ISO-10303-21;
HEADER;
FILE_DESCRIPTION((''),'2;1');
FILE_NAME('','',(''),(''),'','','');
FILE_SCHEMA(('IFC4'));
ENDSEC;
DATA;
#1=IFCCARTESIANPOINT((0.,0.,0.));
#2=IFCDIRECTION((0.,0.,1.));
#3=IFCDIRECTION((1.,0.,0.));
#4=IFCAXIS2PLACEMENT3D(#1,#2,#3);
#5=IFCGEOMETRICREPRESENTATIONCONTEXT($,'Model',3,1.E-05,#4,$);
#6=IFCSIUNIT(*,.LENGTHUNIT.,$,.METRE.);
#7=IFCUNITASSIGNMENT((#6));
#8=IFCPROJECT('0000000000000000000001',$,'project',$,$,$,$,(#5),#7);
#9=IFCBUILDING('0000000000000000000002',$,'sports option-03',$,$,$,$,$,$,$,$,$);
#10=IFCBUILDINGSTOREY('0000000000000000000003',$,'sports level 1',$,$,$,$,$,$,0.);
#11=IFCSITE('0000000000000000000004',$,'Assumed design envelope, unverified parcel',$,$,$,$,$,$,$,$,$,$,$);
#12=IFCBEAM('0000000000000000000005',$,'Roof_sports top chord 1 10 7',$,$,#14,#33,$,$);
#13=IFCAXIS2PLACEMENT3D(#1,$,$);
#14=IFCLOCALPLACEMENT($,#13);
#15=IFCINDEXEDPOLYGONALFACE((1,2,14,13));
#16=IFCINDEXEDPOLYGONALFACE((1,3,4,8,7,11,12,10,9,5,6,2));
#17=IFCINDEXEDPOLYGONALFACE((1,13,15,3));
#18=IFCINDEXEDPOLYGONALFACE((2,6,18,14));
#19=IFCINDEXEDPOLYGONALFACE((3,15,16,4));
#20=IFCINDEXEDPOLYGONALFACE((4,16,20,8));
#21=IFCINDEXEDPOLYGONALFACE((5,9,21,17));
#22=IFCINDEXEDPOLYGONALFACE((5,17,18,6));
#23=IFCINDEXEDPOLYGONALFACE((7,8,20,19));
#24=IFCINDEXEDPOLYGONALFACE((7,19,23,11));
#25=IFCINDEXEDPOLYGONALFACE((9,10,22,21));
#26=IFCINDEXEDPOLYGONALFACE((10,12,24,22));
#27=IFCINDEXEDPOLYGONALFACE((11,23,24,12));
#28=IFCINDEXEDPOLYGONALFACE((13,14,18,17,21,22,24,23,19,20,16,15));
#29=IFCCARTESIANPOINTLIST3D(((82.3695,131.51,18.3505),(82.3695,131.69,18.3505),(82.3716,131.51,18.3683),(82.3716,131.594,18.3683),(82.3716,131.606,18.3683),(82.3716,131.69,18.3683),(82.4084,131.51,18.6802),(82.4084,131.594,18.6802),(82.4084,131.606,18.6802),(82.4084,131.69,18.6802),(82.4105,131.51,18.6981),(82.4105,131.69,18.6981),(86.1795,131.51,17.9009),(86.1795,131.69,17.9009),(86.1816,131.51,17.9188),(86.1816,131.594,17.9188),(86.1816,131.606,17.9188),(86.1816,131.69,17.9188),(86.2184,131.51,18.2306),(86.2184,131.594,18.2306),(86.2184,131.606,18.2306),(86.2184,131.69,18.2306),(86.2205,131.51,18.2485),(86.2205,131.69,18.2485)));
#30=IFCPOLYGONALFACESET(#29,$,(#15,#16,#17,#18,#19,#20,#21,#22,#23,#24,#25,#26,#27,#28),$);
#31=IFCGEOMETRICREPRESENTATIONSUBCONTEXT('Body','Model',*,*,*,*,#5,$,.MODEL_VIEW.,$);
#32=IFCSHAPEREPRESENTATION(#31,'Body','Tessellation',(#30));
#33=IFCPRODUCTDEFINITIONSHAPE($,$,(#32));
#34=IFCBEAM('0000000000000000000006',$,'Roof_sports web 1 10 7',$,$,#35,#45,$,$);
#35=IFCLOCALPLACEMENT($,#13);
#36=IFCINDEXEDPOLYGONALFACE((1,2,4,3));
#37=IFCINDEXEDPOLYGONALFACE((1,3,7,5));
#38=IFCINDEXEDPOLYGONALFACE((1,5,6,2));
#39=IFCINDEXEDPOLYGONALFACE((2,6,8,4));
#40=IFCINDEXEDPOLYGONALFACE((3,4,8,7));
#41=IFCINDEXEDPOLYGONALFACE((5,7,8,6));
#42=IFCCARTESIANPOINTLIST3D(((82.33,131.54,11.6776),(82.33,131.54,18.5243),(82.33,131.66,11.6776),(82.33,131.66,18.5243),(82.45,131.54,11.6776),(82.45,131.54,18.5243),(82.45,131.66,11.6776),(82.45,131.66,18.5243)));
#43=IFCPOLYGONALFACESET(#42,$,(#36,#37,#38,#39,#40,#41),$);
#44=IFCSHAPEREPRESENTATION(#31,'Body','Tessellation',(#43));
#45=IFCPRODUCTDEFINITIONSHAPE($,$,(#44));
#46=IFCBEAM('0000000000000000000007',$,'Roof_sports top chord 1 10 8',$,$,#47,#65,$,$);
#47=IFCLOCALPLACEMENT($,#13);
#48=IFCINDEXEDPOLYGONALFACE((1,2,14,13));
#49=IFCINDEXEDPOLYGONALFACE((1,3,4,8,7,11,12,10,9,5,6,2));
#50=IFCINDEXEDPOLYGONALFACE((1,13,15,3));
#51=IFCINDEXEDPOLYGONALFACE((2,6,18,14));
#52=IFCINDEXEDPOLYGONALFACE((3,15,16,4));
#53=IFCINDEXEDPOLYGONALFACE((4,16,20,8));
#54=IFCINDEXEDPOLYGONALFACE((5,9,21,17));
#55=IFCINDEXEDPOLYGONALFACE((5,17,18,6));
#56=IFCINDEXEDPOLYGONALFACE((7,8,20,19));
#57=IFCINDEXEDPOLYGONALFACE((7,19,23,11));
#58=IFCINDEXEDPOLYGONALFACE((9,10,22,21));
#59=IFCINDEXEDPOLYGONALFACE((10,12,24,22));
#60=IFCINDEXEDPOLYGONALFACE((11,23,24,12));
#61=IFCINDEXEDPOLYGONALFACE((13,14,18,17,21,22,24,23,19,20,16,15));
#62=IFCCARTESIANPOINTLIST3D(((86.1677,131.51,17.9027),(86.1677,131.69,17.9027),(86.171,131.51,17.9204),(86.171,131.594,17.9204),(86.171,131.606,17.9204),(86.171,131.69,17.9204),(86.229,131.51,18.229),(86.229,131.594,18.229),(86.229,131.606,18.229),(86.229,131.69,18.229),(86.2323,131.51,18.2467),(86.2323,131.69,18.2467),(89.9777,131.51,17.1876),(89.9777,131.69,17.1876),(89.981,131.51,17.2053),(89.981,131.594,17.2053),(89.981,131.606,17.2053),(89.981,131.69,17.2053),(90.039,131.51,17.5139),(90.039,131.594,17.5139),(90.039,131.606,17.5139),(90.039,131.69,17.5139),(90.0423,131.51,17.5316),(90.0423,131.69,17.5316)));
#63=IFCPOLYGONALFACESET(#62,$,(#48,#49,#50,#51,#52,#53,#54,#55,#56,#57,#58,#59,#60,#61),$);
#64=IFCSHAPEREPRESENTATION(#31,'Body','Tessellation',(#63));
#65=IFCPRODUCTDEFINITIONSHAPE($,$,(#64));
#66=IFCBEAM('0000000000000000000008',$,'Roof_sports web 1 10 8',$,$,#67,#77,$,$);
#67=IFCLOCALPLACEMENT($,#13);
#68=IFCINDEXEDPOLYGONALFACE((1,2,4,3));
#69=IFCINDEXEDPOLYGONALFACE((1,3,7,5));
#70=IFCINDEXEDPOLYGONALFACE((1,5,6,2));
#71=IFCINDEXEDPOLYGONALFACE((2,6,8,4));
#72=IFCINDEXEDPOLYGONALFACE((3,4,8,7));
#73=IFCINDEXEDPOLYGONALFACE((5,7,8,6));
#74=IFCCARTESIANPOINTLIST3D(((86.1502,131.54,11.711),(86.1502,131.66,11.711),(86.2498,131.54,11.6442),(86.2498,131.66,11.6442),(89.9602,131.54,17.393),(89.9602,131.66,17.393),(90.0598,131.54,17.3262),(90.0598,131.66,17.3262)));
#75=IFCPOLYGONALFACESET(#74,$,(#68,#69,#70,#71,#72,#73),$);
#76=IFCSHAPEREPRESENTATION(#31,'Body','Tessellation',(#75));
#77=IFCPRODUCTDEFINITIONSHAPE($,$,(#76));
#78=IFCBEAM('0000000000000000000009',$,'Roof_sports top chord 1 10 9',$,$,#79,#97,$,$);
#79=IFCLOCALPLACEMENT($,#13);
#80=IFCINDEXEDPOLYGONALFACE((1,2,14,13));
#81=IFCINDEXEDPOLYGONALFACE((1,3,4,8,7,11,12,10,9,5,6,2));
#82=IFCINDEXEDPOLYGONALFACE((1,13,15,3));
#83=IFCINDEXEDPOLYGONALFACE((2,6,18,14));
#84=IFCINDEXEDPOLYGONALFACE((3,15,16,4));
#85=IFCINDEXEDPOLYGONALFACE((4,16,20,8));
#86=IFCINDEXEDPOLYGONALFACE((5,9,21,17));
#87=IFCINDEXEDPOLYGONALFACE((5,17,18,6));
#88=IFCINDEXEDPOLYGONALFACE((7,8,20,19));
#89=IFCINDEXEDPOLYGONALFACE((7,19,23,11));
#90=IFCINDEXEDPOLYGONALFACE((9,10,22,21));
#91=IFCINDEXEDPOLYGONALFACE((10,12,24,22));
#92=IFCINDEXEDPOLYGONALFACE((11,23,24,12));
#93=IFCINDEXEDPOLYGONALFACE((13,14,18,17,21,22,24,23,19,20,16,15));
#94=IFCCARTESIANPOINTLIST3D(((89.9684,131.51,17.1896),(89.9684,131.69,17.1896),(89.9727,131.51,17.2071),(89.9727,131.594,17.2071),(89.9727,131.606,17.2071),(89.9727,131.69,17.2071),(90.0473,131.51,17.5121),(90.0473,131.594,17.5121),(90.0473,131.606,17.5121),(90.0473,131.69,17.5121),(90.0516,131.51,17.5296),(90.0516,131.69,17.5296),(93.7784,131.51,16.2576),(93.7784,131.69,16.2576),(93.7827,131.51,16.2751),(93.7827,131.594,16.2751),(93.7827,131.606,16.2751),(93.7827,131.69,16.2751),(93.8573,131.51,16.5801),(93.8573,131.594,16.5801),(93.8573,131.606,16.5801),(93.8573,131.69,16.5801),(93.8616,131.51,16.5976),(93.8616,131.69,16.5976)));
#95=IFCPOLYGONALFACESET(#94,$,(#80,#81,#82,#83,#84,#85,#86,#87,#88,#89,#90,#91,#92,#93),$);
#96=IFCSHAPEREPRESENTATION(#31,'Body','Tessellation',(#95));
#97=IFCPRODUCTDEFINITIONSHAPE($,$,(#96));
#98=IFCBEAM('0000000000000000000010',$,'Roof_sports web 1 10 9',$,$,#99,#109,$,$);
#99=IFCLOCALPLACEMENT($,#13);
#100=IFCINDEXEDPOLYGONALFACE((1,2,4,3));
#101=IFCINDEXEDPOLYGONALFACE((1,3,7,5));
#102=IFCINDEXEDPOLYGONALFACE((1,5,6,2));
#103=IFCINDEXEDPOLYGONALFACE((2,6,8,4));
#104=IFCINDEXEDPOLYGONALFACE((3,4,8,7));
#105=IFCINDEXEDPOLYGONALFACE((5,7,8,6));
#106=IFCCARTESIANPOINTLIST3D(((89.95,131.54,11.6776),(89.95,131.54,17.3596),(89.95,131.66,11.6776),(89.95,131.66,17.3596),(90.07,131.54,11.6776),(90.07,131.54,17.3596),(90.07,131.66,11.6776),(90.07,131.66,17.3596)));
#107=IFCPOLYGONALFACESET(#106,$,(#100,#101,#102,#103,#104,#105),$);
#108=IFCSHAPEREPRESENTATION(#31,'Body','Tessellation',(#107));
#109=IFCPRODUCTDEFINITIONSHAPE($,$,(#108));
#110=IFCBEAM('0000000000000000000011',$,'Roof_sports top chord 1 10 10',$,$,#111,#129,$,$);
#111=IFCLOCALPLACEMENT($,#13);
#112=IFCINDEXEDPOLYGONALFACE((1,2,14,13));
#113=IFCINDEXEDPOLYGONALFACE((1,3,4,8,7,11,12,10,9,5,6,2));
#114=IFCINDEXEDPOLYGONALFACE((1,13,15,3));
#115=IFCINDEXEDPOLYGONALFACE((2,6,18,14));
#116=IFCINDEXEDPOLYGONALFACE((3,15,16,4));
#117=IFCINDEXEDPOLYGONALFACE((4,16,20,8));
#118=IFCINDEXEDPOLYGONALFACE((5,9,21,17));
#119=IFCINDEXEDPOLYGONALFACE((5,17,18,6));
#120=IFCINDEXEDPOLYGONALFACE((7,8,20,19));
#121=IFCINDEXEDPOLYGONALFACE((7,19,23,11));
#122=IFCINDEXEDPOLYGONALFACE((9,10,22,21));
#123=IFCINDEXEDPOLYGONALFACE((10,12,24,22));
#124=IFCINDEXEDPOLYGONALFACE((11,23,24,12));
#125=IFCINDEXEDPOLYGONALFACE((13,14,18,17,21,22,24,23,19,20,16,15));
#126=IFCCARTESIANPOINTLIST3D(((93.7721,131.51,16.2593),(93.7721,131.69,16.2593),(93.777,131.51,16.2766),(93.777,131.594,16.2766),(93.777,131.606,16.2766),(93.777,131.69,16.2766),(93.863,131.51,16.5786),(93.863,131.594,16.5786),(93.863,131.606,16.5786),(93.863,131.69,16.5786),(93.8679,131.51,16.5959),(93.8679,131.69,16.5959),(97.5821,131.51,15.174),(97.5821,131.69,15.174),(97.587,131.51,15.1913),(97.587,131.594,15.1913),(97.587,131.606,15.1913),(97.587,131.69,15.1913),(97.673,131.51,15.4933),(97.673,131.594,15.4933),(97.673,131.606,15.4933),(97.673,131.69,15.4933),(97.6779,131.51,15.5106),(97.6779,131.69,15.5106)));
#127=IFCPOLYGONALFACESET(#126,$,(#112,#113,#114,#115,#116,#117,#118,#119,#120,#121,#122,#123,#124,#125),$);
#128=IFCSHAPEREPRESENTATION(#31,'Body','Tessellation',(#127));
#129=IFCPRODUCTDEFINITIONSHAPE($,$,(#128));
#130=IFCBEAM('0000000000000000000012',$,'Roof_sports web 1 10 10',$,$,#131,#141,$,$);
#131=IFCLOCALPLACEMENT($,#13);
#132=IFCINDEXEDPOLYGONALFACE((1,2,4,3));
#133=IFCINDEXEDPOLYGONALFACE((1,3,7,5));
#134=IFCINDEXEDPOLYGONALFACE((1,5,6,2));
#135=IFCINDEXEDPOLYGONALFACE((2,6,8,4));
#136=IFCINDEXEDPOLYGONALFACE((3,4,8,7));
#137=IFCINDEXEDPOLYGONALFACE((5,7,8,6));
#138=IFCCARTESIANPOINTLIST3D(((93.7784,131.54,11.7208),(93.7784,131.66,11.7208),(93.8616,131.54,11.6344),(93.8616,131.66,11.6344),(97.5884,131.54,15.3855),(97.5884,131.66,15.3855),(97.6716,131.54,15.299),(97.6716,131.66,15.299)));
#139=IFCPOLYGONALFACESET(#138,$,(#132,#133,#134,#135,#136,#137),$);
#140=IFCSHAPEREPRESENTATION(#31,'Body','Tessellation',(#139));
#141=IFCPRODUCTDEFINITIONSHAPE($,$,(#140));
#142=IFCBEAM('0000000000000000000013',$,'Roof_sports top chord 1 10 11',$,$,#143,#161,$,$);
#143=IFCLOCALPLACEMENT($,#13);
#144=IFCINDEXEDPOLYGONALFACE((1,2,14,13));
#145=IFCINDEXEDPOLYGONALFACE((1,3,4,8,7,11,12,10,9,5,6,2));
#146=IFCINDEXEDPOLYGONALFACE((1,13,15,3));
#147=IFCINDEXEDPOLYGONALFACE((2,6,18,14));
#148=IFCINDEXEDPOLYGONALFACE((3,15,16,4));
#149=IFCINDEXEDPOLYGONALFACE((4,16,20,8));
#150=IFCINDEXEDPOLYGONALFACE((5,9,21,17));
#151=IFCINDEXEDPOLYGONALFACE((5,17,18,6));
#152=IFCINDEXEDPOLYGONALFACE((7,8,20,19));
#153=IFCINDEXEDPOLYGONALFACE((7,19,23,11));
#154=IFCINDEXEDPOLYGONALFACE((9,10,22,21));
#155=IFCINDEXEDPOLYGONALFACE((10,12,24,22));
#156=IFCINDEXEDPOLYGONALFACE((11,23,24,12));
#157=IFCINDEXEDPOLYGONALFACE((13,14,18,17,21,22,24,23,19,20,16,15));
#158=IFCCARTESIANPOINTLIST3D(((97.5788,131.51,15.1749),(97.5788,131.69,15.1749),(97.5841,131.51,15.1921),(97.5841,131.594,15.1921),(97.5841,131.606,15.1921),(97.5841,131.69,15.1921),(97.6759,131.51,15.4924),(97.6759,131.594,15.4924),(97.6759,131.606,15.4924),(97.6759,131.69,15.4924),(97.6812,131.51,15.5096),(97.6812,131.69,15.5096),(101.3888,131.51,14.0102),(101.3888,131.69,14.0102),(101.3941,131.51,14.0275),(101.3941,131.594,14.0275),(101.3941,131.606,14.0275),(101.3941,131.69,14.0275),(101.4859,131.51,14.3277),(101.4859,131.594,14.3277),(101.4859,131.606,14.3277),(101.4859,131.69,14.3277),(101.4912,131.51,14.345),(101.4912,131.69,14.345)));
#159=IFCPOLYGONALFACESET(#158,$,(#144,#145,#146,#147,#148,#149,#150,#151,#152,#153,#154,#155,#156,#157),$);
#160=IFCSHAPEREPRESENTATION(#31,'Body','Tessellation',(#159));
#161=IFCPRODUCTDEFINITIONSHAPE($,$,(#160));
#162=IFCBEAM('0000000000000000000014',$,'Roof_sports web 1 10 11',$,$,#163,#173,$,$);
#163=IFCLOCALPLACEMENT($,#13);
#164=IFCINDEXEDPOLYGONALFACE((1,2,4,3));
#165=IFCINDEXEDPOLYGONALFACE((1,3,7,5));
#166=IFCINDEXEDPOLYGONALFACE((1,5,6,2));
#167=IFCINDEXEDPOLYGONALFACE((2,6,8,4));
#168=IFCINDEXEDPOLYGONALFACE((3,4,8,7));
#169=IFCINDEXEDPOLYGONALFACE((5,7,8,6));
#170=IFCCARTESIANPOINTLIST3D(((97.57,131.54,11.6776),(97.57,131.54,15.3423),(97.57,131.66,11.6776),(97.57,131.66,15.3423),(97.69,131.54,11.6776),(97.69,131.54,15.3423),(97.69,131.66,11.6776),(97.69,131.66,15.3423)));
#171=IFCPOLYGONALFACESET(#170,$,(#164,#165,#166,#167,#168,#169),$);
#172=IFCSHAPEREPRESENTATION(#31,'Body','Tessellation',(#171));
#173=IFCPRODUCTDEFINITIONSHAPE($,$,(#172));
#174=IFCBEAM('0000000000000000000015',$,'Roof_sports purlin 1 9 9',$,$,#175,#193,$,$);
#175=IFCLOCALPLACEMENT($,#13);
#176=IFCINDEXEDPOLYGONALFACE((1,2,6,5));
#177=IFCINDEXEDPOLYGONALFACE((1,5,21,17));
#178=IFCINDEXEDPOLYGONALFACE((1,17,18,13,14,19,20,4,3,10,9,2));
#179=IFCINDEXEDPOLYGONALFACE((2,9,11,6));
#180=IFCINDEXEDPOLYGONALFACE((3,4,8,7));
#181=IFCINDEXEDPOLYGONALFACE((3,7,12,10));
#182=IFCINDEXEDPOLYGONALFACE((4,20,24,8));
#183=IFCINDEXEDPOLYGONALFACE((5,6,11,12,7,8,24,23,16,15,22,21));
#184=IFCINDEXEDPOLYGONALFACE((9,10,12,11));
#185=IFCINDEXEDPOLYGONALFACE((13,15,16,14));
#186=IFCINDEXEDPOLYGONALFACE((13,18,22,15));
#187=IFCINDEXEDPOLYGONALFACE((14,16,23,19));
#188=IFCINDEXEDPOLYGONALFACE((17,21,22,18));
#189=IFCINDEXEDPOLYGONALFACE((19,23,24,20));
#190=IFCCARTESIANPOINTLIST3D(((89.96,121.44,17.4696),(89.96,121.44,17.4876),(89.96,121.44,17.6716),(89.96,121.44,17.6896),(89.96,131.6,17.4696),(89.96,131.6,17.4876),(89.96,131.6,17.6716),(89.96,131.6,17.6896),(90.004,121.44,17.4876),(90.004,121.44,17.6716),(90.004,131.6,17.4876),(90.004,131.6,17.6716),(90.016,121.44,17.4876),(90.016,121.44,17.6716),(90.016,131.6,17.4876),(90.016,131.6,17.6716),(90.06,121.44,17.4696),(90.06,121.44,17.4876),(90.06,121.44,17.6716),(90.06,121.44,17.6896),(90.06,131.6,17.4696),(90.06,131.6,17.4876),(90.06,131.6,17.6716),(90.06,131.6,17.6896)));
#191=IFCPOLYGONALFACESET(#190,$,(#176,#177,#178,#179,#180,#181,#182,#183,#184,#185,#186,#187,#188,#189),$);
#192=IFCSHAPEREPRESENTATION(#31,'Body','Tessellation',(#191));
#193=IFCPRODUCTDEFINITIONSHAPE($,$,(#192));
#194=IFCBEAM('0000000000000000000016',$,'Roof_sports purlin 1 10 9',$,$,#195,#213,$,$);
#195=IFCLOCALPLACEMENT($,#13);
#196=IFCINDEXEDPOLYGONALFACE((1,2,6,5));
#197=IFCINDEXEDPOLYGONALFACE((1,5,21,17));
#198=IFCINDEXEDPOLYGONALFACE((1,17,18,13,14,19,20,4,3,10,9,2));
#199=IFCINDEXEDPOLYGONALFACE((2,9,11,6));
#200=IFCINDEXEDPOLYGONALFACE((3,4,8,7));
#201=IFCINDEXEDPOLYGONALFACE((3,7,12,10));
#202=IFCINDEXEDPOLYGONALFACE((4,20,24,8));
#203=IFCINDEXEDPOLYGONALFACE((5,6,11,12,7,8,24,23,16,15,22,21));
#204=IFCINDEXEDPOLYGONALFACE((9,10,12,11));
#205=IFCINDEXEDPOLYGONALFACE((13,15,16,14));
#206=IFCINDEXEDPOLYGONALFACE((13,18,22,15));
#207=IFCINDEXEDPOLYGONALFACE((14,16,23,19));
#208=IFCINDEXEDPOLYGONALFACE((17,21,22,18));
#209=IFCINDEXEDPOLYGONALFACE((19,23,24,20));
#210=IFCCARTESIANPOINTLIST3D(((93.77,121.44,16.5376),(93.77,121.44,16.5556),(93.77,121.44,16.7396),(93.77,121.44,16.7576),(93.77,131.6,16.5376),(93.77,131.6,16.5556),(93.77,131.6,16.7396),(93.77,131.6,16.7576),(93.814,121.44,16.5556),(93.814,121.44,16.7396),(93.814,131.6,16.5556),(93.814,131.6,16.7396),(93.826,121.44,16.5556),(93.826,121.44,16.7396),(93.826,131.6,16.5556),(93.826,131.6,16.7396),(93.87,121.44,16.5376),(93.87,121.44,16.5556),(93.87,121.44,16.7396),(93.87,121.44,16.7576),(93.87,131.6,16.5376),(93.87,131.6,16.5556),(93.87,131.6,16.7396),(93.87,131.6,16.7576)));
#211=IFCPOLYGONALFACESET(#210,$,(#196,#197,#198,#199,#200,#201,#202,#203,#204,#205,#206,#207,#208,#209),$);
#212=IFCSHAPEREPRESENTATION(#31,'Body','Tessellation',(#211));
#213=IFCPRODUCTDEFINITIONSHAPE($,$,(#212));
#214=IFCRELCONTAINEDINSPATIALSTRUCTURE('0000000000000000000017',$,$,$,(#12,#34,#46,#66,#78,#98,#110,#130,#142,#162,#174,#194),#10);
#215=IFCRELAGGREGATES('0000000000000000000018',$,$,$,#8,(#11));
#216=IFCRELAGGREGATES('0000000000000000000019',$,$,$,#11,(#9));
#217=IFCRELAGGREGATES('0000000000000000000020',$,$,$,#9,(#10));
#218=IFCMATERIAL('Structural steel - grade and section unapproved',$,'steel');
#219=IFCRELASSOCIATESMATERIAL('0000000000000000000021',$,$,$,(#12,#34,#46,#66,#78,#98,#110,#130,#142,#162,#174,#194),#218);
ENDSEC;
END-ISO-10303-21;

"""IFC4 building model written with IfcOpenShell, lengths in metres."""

from ifc_helpers import new_model, si_unit, frame, origin_with_axes, place, context, subcontext, project, spatial, rectangle, i_section, extrude, material, element, save


model = new_model("IFC4")

# Units and contexts
model_context = context("Model", 3, precision=1e-05, world=origin_with_axes())
body_context = subcontext(model_context, "Body", "Model", "MODEL_VIEW")
ifc_project = project(units=[si_unit("LENGTHUNIT", "METRE")], contexts=[model_context])

# Site, building, storey
site = spatial("IfcSite", under=ifc_project, Name="Assumed design envelope, unverified parcel")
building = spatial("IfcBuilding", under=site, Name="sports option-03")
storey = spatial("IfcBuildingStorey", under=building, Name="sports level 1", Elevation=0.0)

# Shared definitions
ifc_material_1 = material(Name="Structural steel - grade and section unapproved", Category="steel")

# Beams
beam_1_placement = place(None, frame((82.39, 131.6, 18.5243), z_axis=(0.993111, 0.0, -0.11718), x_axis=(0.0, 1.0, 0.0)))
element("IfcBeam", 1, at=beam_1_placement, inside=storey, material=ifc_material_1, Name="Roof_sports top chord 1 10 7", context=body_context, shape_type="SweptSolid", body=[
    extrude(i_section(OverallWidth=0.18, OverallDepth=0.35, WebThickness=0.012, FlangeThickness=0.018, FilletRadius=0.0), origin_with_axes(), (0.0, 0.0, 1.0), 3.8364),
])
beam_2_placement = place(None, frame((82.39, 131.6, 11.6776), z_axis=(0.0, 0.0, 1.0), x_axis=(-1.0, 0.0, 0.0)))
element("IfcBeam", 2, at=beam_2_placement, inside=storey, material=ifc_material_1, Name="Roof_sports web 1 10 7", context=body_context, shape_type="SweptSolid", body=[
    extrude(rectangle(XDim=0.12, YDim=0.12), origin_with_axes(), (0.0, 0.0, 1.0), 6.8467),
])
beam_3_placement = place(None, frame((86.2, 131.6, 18.0747), z_axis=(0.982837, 0.0, -0.184478), x_axis=(0.0, 1.0, 0.0)))
element("IfcBeam", 3, at=beam_3_placement, inside=storey, material=ifc_material_1, Name="Roof_sports top chord 1 10 8", context=body_context, shape_type="SweptSolid", body=[
    extrude(i_section(OverallWidth=0.18, OverallDepth=0.35, WebThickness=0.012, FlangeThickness=0.018, FilletRadius=0.0), origin_with_axes(), (0.0, 0.0, 1.0), 3.8765),
])
beam_4_placement = place(None, frame((86.2, 131.6, 11.6776), z_axis=(0.556926, 0.0, 0.830562), x_axis=(0.0, 1.0, 0.0)))
element("IfcBeam", 4, at=beam_4_placement, inside=storey, material=ifc_material_1, Name="Roof_sports web 1 10 8", context=body_context, shape_type="SweptSolid", body=[
    extrude(rectangle(XDim=0.12, YDim=0.12), origin_with_axes(), (0.0, 0.0, 1.0), 6.8411),
])
beam_5_placement = place(None, frame((90.01, 131.6, 17.3596), z_axis=(0.971361, 0.0, -0.237609), x_axis=(0.0, 1.0, 0.0)))
element("IfcBeam", 5, at=beam_5_placement, inside=storey, material=ifc_material_1, Name="Roof_sports top chord 1 10 9", context=body_context, shape_type="SweptSolid", body=[
    extrude(i_section(OverallWidth=0.18, OverallDepth=0.35, WebThickness=0.012, FlangeThickness=0.018, FilletRadius=0.0), origin_with_axes(), (0.0, 0.0, 1.0), 3.9223),
])
beam_6_placement = place(None, frame((90.01, 131.6, 11.6776), z_axis=(0.0, 0.0, 1.0), x_axis=(-1.0, 0.0, 0.0)))
element("IfcBeam", 6, at=beam_6_placement, inside=storey, material=ifc_material_1, Name="Roof_sports web 1 10 9", context=body_context, shape_type="SweptSolid", body=[
    extrude(rectangle(XDim=0.12, YDim=0.12), origin_with_axes(), (0.0, 0.0, 1.0), 5.682),
])
beam_7_placement = place(None, frame((93.82, 131.6, 16.4276), z_axis=(0.961741, 0.0, -0.273961), x_axis=(0.0, 1.0, 0.0)))
element("IfcBeam", 7, at=beam_7_placement, inside=storey, material=ifc_material_1, Name="Roof_sports top chord 1 10 10", context=body_context, shape_type="SweptSolid", body=[
    extrude(i_section(OverallWidth=0.18, OverallDepth=0.35, WebThickness=0.012, FlangeThickness=0.018, FilletRadius=0.0), origin_with_axes(), (0.0, 0.0, 1.0), 3.9616),
])
beam_8_placement = place(None, frame((93.82, 131.6, 11.6776), z_axis=(0.720717, 0.0, 0.693229), x_axis=(0.0, 1.0, 0.0)))
element("IfcBeam", 8, at=beam_8_placement, inside=storey, material=ifc_material_1, Name="Roof_sports web 1 10 10", context=body_context, shape_type="SweptSolid", body=[
    extrude(rectangle(XDim=0.12, YDim=0.12), origin_with_axes(), (0.0, 0.0, 1.0), 5.2864),
])
beam_9_placement = place(None, frame((97.63, 131.6, 15.3423), z_axis=(0.956315, 0.0, -0.292337), x_axis=(0.0, 1.0, 0.0)))
element("IfcBeam", 9, at=beam_9_placement, inside=storey, material=ifc_material_1, Name="Roof_sports top chord 1 10 11", context=body_context, shape_type="SweptSolid", body=[
    extrude(i_section(OverallWidth=0.18, OverallDepth=0.35, WebThickness=0.012, FlangeThickness=0.018, FilletRadius=0.0), origin_with_axes(), (0.0, 0.0, 1.0), 3.984),
])
beam_10_placement = place(None, frame((97.63, 131.6, 11.6776), z_axis=(0.0, 0.0, 1.0), x_axis=(-1.0, 0.0, 0.0)))
element("IfcBeam", 10, at=beam_10_placement, inside=storey, material=ifc_material_1, Name="Roof_sports web 1 10 11", context=body_context, shape_type="SweptSolid", body=[
    extrude(rectangle(XDim=0.12, YDim=0.12), origin_with_axes(), (0.0, 0.0, 1.0), 3.6647),
])
for number, where, z_axis, x_axis, name in (
    (11, (90.01, 121.44, 17.5796), (0.0, 1.0, 0.0), (-1.0, 0.0, 0.0), "Roof_sports purlin 1 9 9"),
    (12, (93.82, 121.44, 16.6476), (0.0, 1.0, 0.0), (-1.0, 0.0, 0.0), "Roof_sports purlin 1 10 9"),
):
    element("IfcBeam", number, at=place(None, frame(where, z_axis=z_axis, x_axis=x_axis)), inside=storey, material=ifc_material_1, Name=name, context=body_context, shape_type="SweptSolid", body=[
        extrude(i_section(OverallWidth=0.1, OverallDepth=0.22, WebThickness=0.012, FlangeThickness=0.018, FilletRadius=0.0), origin_with_axes(), (0.0, 0.0, 1.0), 10.16),
    ])

save(model, "model.ifc")
